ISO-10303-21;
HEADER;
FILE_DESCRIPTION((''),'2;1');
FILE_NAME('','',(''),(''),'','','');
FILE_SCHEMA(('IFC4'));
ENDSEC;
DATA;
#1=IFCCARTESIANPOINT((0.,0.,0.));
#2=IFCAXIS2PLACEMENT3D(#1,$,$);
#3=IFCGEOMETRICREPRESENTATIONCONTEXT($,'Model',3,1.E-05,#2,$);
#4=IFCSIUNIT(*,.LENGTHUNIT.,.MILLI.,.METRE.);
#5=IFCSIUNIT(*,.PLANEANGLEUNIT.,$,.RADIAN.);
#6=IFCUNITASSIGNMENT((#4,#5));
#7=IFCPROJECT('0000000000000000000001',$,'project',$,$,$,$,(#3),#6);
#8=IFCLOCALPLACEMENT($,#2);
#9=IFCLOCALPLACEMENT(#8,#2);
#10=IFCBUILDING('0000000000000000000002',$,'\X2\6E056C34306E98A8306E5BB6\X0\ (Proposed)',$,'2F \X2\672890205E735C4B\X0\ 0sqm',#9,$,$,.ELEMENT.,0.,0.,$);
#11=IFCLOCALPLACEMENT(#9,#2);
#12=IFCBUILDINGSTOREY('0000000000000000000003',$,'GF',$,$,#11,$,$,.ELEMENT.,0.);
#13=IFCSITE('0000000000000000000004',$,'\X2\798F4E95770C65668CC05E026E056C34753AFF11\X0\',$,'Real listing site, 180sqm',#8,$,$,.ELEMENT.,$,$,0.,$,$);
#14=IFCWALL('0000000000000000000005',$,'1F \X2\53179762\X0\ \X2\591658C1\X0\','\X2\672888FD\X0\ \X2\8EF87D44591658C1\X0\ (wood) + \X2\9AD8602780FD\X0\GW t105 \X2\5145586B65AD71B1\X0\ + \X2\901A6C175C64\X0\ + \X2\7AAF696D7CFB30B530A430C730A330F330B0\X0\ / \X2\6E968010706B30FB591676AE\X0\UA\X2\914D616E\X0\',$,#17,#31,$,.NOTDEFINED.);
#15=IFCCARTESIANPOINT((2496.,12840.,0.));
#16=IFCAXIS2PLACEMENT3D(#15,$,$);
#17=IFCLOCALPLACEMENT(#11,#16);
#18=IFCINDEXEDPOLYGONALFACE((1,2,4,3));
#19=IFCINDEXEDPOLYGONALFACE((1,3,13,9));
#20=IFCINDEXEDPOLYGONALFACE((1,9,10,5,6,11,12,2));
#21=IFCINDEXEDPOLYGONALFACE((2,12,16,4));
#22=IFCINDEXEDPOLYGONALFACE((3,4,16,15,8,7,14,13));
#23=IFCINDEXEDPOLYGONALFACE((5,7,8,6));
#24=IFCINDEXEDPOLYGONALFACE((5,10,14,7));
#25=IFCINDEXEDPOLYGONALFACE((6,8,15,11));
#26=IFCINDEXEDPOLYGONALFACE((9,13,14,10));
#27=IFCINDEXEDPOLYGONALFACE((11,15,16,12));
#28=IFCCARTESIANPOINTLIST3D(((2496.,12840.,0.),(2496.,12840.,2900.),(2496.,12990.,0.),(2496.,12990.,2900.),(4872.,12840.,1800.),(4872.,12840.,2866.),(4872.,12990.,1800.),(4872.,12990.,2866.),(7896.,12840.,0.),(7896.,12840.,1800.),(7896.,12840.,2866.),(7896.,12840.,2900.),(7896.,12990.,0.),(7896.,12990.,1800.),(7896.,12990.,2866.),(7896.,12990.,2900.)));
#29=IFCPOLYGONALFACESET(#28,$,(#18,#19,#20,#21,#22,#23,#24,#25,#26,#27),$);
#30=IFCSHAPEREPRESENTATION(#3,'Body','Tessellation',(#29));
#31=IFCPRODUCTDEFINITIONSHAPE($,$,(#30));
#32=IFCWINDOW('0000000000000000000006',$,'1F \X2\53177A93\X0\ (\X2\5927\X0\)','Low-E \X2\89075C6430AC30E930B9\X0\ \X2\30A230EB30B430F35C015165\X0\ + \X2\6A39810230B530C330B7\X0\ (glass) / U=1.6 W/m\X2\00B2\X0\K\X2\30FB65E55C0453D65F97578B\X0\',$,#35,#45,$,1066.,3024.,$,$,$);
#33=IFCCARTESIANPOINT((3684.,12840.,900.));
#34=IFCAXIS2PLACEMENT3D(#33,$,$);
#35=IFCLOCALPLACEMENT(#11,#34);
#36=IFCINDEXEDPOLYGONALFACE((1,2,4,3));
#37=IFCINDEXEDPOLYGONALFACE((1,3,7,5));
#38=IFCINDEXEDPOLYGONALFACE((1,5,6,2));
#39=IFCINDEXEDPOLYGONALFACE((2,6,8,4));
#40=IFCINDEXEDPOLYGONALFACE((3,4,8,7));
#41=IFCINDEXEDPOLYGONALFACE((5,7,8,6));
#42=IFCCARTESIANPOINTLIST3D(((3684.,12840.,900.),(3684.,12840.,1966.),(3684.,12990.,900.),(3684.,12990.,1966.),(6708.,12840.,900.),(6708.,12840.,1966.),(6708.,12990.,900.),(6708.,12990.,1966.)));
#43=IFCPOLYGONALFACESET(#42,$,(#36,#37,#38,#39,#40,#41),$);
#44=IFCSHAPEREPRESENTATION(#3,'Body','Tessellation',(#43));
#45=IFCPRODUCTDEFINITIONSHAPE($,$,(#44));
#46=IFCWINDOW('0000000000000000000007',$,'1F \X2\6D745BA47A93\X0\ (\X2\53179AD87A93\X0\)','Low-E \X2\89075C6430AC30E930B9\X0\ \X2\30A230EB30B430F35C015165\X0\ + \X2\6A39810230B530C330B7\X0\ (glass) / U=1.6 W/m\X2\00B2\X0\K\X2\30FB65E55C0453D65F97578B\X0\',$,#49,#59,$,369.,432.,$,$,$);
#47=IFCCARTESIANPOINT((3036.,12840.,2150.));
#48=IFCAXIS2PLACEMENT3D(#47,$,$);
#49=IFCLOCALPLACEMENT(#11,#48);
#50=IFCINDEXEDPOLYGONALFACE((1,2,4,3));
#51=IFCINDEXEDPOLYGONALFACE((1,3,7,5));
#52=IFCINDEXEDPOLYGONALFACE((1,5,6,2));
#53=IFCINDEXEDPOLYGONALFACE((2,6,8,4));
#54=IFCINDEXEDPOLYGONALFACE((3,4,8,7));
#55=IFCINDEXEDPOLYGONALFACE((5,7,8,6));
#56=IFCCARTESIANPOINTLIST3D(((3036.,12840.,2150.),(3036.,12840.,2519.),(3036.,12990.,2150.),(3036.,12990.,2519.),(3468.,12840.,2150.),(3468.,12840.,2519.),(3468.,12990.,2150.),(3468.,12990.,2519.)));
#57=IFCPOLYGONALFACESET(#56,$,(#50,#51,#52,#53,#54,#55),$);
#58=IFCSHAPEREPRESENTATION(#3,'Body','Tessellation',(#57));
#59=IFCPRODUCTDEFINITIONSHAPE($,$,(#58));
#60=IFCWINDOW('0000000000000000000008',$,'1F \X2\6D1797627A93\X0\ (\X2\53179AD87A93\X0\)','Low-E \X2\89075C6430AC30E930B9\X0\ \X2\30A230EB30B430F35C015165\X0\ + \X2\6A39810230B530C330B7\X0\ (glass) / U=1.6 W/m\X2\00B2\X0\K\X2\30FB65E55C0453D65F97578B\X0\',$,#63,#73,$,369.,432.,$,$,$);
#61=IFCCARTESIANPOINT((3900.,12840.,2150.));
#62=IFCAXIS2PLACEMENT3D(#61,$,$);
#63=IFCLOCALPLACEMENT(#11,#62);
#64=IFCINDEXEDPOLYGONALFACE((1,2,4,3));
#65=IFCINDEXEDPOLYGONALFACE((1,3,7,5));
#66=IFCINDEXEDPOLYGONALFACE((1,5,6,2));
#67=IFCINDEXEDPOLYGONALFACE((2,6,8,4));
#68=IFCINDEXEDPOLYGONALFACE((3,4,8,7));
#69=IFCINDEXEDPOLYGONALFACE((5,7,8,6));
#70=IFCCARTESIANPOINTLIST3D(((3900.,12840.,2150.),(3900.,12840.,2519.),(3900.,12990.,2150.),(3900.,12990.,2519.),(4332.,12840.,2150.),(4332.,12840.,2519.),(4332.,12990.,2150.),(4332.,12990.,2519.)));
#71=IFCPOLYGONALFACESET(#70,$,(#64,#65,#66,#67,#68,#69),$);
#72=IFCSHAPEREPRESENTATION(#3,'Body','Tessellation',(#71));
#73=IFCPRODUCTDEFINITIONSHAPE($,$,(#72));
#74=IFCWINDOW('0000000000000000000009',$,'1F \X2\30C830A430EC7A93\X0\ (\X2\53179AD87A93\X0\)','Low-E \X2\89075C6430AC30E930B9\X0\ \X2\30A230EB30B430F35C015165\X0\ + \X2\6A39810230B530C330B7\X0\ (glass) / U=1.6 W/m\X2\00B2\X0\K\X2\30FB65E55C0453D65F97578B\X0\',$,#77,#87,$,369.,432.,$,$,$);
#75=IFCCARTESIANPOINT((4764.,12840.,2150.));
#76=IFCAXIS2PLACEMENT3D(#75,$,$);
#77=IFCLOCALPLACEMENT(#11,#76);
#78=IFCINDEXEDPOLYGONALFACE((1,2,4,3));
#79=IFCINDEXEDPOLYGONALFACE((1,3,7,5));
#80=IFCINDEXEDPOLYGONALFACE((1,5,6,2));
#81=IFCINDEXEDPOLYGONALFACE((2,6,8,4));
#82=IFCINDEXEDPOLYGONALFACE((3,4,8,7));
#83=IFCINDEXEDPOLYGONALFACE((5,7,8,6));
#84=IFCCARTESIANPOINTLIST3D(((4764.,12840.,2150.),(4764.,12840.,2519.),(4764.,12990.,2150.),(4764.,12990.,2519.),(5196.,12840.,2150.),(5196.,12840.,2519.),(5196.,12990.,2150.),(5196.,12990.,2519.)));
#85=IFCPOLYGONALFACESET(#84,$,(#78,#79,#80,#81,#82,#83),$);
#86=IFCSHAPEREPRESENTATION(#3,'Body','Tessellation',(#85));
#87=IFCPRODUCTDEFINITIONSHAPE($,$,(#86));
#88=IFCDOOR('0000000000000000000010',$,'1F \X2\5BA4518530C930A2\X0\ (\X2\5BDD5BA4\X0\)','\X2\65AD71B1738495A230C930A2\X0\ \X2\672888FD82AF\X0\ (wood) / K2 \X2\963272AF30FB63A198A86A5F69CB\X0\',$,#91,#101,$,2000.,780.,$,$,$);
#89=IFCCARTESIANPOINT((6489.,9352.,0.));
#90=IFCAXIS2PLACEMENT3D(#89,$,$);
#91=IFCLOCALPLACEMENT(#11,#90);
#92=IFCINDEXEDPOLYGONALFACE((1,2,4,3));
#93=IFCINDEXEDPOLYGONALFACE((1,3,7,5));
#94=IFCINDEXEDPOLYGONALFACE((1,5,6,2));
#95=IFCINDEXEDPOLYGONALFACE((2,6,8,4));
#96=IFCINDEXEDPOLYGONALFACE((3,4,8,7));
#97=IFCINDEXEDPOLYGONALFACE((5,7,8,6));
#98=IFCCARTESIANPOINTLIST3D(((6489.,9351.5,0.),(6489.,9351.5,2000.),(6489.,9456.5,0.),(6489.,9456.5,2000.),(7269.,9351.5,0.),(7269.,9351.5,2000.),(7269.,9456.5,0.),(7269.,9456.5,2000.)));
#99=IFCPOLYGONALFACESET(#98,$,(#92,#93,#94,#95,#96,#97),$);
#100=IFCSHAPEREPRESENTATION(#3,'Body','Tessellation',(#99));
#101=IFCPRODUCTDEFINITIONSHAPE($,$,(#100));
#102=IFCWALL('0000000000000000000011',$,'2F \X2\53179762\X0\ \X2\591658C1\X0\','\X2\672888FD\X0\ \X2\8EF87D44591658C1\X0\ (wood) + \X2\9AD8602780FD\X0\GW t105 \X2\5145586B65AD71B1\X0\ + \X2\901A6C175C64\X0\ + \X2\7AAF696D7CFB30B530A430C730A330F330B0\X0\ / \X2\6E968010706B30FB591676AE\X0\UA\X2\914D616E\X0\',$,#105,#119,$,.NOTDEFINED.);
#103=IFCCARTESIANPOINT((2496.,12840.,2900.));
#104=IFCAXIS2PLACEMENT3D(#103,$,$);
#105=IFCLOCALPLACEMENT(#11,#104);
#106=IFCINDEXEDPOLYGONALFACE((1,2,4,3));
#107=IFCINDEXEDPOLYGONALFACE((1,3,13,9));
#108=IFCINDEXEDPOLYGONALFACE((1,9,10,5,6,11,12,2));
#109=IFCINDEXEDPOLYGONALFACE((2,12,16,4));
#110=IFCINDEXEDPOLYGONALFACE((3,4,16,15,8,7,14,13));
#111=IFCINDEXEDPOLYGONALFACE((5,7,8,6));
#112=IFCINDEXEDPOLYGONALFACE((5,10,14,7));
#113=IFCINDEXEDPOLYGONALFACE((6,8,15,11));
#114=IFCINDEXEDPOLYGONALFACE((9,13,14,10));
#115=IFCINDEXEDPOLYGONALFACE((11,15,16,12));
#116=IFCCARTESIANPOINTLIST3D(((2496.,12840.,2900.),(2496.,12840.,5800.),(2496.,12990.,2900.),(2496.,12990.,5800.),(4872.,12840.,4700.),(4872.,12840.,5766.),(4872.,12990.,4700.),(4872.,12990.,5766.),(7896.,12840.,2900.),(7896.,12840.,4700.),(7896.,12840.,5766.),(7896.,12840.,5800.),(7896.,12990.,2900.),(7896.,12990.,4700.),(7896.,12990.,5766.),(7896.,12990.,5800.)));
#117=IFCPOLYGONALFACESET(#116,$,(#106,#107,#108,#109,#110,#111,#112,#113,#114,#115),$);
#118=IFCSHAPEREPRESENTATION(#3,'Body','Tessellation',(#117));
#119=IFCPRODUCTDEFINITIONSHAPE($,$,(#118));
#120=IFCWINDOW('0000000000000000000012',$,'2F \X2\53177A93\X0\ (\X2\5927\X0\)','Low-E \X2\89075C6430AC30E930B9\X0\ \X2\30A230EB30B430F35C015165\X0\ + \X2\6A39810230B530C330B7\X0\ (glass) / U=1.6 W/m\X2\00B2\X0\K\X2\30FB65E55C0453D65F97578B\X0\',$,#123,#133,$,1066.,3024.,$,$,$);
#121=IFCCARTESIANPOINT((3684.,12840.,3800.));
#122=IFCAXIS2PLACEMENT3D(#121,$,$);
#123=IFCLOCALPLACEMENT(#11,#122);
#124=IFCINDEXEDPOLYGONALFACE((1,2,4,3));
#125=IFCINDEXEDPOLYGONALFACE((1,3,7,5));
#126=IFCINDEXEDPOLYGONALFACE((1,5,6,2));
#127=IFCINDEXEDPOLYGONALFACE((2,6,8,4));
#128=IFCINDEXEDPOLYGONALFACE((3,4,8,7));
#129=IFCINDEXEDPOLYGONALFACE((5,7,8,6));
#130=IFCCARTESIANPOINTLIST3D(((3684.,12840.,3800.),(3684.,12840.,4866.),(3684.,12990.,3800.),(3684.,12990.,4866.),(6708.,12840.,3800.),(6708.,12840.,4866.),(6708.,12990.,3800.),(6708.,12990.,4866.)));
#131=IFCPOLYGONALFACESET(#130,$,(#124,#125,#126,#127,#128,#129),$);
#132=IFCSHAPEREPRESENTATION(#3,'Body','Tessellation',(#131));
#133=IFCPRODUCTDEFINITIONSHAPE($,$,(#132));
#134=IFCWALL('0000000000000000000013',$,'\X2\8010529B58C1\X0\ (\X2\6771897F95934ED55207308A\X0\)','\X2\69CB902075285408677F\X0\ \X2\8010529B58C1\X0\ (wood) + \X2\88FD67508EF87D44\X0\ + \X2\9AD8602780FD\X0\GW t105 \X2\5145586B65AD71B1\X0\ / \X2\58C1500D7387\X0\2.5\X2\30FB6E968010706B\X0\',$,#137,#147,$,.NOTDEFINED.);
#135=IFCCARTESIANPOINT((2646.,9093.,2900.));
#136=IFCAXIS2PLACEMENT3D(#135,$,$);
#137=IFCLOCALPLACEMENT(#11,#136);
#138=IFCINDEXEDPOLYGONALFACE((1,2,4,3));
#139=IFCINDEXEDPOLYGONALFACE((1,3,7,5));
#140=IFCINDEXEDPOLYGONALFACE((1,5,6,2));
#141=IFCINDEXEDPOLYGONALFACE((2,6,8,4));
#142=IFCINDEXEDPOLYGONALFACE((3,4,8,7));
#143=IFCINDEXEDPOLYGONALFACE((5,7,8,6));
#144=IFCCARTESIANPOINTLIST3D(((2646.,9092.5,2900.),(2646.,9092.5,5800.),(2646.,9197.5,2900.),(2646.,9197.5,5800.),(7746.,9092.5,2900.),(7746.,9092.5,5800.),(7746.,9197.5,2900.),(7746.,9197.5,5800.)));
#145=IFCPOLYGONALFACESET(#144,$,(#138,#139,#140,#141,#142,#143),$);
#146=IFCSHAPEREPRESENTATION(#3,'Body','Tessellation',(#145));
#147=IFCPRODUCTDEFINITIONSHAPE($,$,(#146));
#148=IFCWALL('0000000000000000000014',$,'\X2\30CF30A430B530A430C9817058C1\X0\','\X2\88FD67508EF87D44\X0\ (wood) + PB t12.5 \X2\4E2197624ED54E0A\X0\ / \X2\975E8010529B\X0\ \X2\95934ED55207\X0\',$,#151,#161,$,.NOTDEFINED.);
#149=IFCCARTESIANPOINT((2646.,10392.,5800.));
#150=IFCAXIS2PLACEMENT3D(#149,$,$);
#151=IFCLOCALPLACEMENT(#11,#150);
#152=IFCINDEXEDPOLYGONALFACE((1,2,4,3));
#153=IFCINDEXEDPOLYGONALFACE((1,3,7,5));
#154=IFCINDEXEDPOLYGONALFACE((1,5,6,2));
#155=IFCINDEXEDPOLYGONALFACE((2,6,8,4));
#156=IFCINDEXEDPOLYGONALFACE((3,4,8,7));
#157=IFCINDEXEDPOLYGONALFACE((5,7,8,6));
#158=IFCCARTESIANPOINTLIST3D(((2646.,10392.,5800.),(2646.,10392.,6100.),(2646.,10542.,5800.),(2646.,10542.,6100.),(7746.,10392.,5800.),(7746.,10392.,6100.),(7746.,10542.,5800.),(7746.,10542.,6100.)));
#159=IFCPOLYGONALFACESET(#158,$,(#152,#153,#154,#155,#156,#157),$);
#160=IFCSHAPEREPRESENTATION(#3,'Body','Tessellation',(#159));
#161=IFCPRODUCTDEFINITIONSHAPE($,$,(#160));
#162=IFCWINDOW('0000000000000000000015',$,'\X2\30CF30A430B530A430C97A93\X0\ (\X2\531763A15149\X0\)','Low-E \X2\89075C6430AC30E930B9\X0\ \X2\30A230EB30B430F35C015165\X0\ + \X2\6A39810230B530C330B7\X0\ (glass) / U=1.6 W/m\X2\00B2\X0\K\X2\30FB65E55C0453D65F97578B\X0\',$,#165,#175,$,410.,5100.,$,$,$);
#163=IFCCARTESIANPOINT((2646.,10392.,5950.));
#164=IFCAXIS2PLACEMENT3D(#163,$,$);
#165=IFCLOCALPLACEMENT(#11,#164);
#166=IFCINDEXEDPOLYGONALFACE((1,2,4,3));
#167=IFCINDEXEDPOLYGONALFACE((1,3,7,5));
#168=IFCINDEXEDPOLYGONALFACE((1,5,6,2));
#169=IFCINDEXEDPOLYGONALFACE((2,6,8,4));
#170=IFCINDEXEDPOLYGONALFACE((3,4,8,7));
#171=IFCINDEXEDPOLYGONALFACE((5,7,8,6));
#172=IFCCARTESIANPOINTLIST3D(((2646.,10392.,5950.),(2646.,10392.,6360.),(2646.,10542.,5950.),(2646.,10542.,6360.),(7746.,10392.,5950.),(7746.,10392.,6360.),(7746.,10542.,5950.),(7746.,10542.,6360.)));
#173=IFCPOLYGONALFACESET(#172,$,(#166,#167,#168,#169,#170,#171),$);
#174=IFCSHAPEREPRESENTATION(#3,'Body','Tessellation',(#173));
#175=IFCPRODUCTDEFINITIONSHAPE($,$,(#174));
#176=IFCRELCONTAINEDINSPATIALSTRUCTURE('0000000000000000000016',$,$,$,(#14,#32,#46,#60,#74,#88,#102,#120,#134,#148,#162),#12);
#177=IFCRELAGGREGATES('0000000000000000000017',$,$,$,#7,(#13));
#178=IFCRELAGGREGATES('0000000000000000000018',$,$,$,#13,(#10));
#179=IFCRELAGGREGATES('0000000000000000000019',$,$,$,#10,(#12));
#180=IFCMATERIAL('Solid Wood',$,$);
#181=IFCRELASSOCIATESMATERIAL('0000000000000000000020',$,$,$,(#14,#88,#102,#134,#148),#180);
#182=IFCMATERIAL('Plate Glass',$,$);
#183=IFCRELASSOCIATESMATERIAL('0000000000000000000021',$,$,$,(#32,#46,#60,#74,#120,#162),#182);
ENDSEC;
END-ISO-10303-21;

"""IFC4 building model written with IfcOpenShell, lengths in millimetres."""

from ifc_helpers import new_model, si_unit, frame, frame_2d, origin, place, context, project, spatial, rectangle, extrude, material, element, fill, save


model = new_model("IFC4")

# Units and contexts
model_context = context("Model", 3, precision=1e-05, world=origin())
ifc_project = project(units=[si_unit("LENGTHUNIT", "METRE", prefix="MILLI"), si_unit("PLANEANGLEUNIT", "RADIAN")], contexts=[model_context])

# Site, building, storey
site_placement = place(None, origin())
site = spatial("IfcSite", under=ifc_project, at=site_placement, Name="福井県敦賀市清水町１", ObjectType="Real listing site, 180sqm", CompositionType="ELEMENT", RefElevation=0.0)
building_placement = place(site_placement, origin())
building = spatial("IfcBuilding", under=site, at=building_placement, Name="清水の風の家 (Proposed)", ObjectType="2F 木造平屋 0sqm", CompositionType="ELEMENT", ElevationOfRefHeight=0.0, ElevationOfTerrain=0.0)
storey_placement = place(building_placement, origin())
storey = spatial("IfcBuildingStorey", under=building, at=storey_placement, Name="GF", CompositionType="ELEMENT", Elevation=0.0)

# Wall, openings, windows
ifc_material_1 = material(Name="Solid Wood")
wall_1_placement = place(storey_placement, frame((2496.0, 12840.0, 0.0)))
wall_1 = element("IfcWall", 1, at=wall_1_placement, inside=storey, material=ifc_material_1, Name="1F 北面 外壁", Description="木製 軸組外壁 (wood) + 高性能GW t105 充填断熱 + 通気層 + 窯業系サイディング / 準耐火・外皮UA配慮", PredefinedType="NOTDEFINED", context=model_context, shape_type="SweptSolid", body=[
    extrude(rectangle(XDim=5400.0, YDim=150.0, at=frame_2d((2700.0, 75.0))), frame((2496.0, 12840.0, 0.0)), (0.0, 0.0, 1.0), 2900.0),
])
opening_1_placement = place(storey_placement, frame((3684.0, 12840.0, 900.0)))
opening_1 = element("IfcOpeningElement", 2, at=opening_1_placement, cuts=wall_1, PredefinedType="NOTDEFINED", context=model_context, shape_type="SweptSolid", body=[
    extrude(rectangle(XDim=3024.0, YDim=150.0, at=frame_2d((1512.0, 75.0))), frame((3684.0, 12840.0, 900.0)), (0.0, 0.0, 1.0), 1066.0),
])
opening_2_placement = place(storey_placement, frame((3036.0, 12840.0, 2150.0)))
opening_2 = element("IfcOpeningElement", 3, at=opening_2_placement, cuts=wall_1, PredefinedType="NOTDEFINED", context=model_context, shape_type="SweptSolid", body=[
    extrude(rectangle(XDim=432.0, YDim=150.0, at=frame_2d((216.0, 75.0))), frame((3036.0, 12840.0, 2150.0)), (0.0, 0.0, 1.0), 369.0),
])
opening_3_placement = place(storey_placement, frame((3900.0, 12840.0, 2150.0)))
opening_3 = element("IfcOpeningElement", 4, at=opening_3_placement, cuts=wall_1, PredefinedType="NOTDEFINED", context=model_context, shape_type="SweptSolid", body=[
    extrude(rectangle(XDim=432.0, YDim=150.0, at=frame_2d((216.0, 75.0))), frame((3900.0, 12840.0, 2150.0)), (0.0, 0.0, 1.0), 369.0),
])
opening_4_placement = place(storey_placement, frame((4764.0, 12840.0, 2150.0)))
opening_4 = element("IfcOpeningElement", 5, at=opening_4_placement, cuts=wall_1, PredefinedType="NOTDEFINED", context=model_context, shape_type="SweptSolid", body=[
    extrude(rectangle(XDim=432.0, YDim=150.0, at=frame_2d((216.0, 75.0))), frame((4764.0, 12840.0, 2150.0)), (0.0, 0.0, 1.0), 369.0),
])
ifc_material_2 = material(Name="Plate Glass")
window_1_placement = place(storey_placement, frame((3684.0, 12840.0, 900.0)))
window_1 = element("IfcWindow", 6, at=window_1_placement, inside=storey, material=ifc_material_2, Name="1F 北窓 (大)", Description="Low-E 複層ガラス アルゴン封入 + 樹脂サッシ (glass) / U=1.6 W/m²K・日射取得型", OverallHeight=1066.0, OverallWidth=3024.0, context=model_context, shape_type="SweptSolid", body=[
    extrude(rectangle(XDim=3024.0, YDim=150.0, at=frame_2d((1512.0, 75.0))), frame((3684.0, 12840.0, 900.0)), (0.0, 0.0, 1.0), 1066.0),
])
fill(opening_1, window_1)
window_2_placement = place(storey_placement, frame((3036.0, 12840.0, 2150.0)))
window_2 = element("IfcWindow", 7, at=window_2_placement, inside=storey, material=ifc_material_2, Name="1F 浴室窓 (北高窓)", Description="Low-E 複層ガラス アルゴン封入 + 樹脂サッシ (glass) / U=1.6 W/m²K・日射取得型", OverallHeight=369.0, OverallWidth=432.0, context=model_context, shape_type="SweptSolid", body=[
    extrude(rectangle(XDim=432.0, YDim=150.0, at=frame_2d((216.0, 75.0))), frame((3036.0, 12840.0, 2150.0)), (0.0, 0.0, 1.0), 369.0),
])
fill(opening_2, window_2)
window_3_placement = place(storey_placement, frame((3900.0, 12840.0, 2150.0)))
window_3 = element("IfcWindow", 8, at=window_3_placement, inside=storey, material=ifc_material_2, Name="1F 洗面窓 (北高窓)", Description="Low-E 複層ガラス アルゴン封入 + 樹脂サッシ (glass) / U=1.6 W/m²K・日射取得型", OverallHeight=369.0, OverallWidth=432.0, context=model_context, shape_type="SweptSolid", body=[
    extrude(rectangle(XDim=432.0, YDim=150.0, at=frame_2d((216.0, 75.0))), frame((3900.0, 12840.0, 2150.0)), (0.0, 0.0, 1.0), 369.0),
])
fill(opening_3, window_3)
window_4_placement = place(storey_placement, frame((4764.0, 12840.0, 2150.0)))
window_4 = element("IfcWindow", 9, at=window_4_placement, inside=storey, material=ifc_material_2, Name="1F トイレ窓 (北高窓)", Description="Low-E 複層ガラス アルゴン封入 + 樹脂サッシ (glass) / U=1.6 W/m²K・日射取得型", OverallHeight=369.0, OverallWidth=432.0, context=model_context, shape_type="SweptSolid", body=[
    extrude(rectangle(XDim=432.0, YDim=150.0, at=frame_2d((216.0, 75.0))), frame((4764.0, 12840.0, 2150.0)), (0.0, 0.0, 1.0), 369.0),
])
fill(opening_4, window_4)

# Door
door_1_placement = place(storey_placement, frame((6489.0, 9352.0, 0.0)))
element("IfcDoor", 10, at=door_1_placement, inside=storey, material=ifc_material_1, Name="1F 室内ドア (寝室)", Description="断熱玄関ドア 木製芯 (wood) / K2 防犯・採風機構", OverallHeight=2000.0, OverallWidth=780.0, context=model_context, shape_type="SweptSolid", body=[
    extrude(rectangle(XDim=780.0, YDim=105.0, at=frame_2d((390.0, 52.0))), frame((6489.0, 9352.0, 0.0)), (0.0, 0.0, 1.0), 2000.0),
])

# Wall, opening, window
wall_2_placement = place(storey_placement, frame((2496.0, 12840.0, 2900.0)))
wall_2 = element("IfcWall", 11, at=wall_2_placement, inside=storey, material=ifc_material_1, Name="2F 北面 外壁", Description="木製 軸組外壁 (wood) + 高性能GW t105 充填断熱 + 通気層 + 窯業系サイディング / 準耐火・外皮UA配慮", PredefinedType="NOTDEFINED", context=model_context, shape_type="SweptSolid", body=[
    extrude(rectangle(XDim=5400.0, YDim=150.0, at=frame_2d((2700.0, 75.0))), frame((2496.0, 12840.0, 2900.0)), (0.0, 0.0, 1.0), 2900.0),
])
opening_5_placement = place(storey_placement, frame((3684.0, 12840.0, 3800.0)))
opening_5 = element("IfcOpeningElement", 12, at=opening_5_placement, cuts=wall_2, PredefinedType="NOTDEFINED", context=model_context, shape_type="SweptSolid", body=[
    extrude(rectangle(XDim=3024.0, YDim=150.0, at=frame_2d((1512.0, 75.0))), frame((3684.0, 12840.0, 3800.0)), (0.0, 0.0, 1.0), 1066.0),
])
window_5_placement = place(storey_placement, frame((3684.0, 12840.0, 3800.0)))
window_5 = element("IfcWindow", 13, at=window_5_placement, inside=storey, material=ifc_material_2, Name="2F 北窓 (大)", Description="Low-E 複層ガラス アルゴン封入 + 樹脂サッシ (glass) / U=1.6 W/m²K・日射取得型", OverallHeight=1066.0, OverallWidth=3024.0, context=model_context, shape_type="SweptSolid", body=[
    extrude(rectangle(XDim=3024.0, YDim=150.0, at=frame_2d((1512.0, 75.0))), frame((3684.0, 12840.0, 3800.0)), (0.0, 0.0, 1.0), 1066.0),
])
fill(opening_5, window_5)

# Wall
wall_3_placement = place(storey_placement, frame((2646.0, 9093.0, 2900.0)))
element("IfcWall", 14, at=wall_3_placement, inside=storey, material=ifc_material_1, Name="耐力壁 (東西間仕切り)", Description="構造用合板 耐力壁 (wood) + 製材軸組 + 高性能GW t105 充填断熱 / 壁倍率2.5・準耐火", PredefinedType="NOTDEFINED", context=model_context, shape_type="SweptSolid", body=[
    extrude(rectangle(XDim=5100.0, YDim=105.0, at=frame_2d((2550.0, 52.0))), frame((2646.0, 9093.0, 2900.0)), (0.0, 0.0, 1.0), 2900.0),
])

# Wall, opening, window
wall_4_placement = place(storey_placement, frame((2646.0, 10392.0, 5800.0)))
wall_4 = element("IfcWall", 15, at=wall_4_placement, inside=storey, material=ifc_material_1, Name="ハイサイド腰壁", Description="製材軸組 (wood) + PB t12.5 両面仕上 / 非耐力 間仕切", PredefinedType="NOTDEFINED", context=model_context, shape_type="SweptSolid", body=[
    extrude(rectangle(XDim=5100.0, YDim=150.0, at=frame_2d((2550.0, 75.0))), frame((2646.0, 10392.0, 5800.0)), (0.0, 0.0, 1.0), 700.0),
])
opening_6_placement = place(storey_placement, frame((2646.0, 10392.0, 5950.0)))
opening_6 = element("IfcOpeningElement", 16, at=opening_6_placement, cuts=wall_4, PredefinedType="NOTDEFINED", context=model_context, shape_type="SweptSolid", body=[
    extrude(rectangle(XDim=5100.0, YDim=150.0, at=frame_2d((2550.0, 75.0))), frame((2646.0, 10392.0, 5950.0)), (0.0, 0.0, 1.0), 410.0),
])
window_6_placement = place(storey_placement, frame((2646.0, 10392.0, 5950.0)))
window_6 = element("IfcWindow", 17, at=window_6_placement, inside=storey, material=ifc_material_2, Name="ハイサイド窓 (北採光)", Description="Low-E 複層ガラス アルゴン封入 + 樹脂サッシ (glass) / U=1.6 W/m²K・日射取得型", OverallHeight=410.0, OverallWidth=5100.0, context=model_context, shape_type="SweptSolid", body=[
    extrude(rectangle(XDim=5100.0, YDim=150.0, at=frame_2d((2550.0, 75.0))), frame((2646.0, 10392.0, 5950.0)), (0.0, 0.0, 1.0), 410.0),
])
fill(opening_6, window_6)

save(model, "model.ifc")
